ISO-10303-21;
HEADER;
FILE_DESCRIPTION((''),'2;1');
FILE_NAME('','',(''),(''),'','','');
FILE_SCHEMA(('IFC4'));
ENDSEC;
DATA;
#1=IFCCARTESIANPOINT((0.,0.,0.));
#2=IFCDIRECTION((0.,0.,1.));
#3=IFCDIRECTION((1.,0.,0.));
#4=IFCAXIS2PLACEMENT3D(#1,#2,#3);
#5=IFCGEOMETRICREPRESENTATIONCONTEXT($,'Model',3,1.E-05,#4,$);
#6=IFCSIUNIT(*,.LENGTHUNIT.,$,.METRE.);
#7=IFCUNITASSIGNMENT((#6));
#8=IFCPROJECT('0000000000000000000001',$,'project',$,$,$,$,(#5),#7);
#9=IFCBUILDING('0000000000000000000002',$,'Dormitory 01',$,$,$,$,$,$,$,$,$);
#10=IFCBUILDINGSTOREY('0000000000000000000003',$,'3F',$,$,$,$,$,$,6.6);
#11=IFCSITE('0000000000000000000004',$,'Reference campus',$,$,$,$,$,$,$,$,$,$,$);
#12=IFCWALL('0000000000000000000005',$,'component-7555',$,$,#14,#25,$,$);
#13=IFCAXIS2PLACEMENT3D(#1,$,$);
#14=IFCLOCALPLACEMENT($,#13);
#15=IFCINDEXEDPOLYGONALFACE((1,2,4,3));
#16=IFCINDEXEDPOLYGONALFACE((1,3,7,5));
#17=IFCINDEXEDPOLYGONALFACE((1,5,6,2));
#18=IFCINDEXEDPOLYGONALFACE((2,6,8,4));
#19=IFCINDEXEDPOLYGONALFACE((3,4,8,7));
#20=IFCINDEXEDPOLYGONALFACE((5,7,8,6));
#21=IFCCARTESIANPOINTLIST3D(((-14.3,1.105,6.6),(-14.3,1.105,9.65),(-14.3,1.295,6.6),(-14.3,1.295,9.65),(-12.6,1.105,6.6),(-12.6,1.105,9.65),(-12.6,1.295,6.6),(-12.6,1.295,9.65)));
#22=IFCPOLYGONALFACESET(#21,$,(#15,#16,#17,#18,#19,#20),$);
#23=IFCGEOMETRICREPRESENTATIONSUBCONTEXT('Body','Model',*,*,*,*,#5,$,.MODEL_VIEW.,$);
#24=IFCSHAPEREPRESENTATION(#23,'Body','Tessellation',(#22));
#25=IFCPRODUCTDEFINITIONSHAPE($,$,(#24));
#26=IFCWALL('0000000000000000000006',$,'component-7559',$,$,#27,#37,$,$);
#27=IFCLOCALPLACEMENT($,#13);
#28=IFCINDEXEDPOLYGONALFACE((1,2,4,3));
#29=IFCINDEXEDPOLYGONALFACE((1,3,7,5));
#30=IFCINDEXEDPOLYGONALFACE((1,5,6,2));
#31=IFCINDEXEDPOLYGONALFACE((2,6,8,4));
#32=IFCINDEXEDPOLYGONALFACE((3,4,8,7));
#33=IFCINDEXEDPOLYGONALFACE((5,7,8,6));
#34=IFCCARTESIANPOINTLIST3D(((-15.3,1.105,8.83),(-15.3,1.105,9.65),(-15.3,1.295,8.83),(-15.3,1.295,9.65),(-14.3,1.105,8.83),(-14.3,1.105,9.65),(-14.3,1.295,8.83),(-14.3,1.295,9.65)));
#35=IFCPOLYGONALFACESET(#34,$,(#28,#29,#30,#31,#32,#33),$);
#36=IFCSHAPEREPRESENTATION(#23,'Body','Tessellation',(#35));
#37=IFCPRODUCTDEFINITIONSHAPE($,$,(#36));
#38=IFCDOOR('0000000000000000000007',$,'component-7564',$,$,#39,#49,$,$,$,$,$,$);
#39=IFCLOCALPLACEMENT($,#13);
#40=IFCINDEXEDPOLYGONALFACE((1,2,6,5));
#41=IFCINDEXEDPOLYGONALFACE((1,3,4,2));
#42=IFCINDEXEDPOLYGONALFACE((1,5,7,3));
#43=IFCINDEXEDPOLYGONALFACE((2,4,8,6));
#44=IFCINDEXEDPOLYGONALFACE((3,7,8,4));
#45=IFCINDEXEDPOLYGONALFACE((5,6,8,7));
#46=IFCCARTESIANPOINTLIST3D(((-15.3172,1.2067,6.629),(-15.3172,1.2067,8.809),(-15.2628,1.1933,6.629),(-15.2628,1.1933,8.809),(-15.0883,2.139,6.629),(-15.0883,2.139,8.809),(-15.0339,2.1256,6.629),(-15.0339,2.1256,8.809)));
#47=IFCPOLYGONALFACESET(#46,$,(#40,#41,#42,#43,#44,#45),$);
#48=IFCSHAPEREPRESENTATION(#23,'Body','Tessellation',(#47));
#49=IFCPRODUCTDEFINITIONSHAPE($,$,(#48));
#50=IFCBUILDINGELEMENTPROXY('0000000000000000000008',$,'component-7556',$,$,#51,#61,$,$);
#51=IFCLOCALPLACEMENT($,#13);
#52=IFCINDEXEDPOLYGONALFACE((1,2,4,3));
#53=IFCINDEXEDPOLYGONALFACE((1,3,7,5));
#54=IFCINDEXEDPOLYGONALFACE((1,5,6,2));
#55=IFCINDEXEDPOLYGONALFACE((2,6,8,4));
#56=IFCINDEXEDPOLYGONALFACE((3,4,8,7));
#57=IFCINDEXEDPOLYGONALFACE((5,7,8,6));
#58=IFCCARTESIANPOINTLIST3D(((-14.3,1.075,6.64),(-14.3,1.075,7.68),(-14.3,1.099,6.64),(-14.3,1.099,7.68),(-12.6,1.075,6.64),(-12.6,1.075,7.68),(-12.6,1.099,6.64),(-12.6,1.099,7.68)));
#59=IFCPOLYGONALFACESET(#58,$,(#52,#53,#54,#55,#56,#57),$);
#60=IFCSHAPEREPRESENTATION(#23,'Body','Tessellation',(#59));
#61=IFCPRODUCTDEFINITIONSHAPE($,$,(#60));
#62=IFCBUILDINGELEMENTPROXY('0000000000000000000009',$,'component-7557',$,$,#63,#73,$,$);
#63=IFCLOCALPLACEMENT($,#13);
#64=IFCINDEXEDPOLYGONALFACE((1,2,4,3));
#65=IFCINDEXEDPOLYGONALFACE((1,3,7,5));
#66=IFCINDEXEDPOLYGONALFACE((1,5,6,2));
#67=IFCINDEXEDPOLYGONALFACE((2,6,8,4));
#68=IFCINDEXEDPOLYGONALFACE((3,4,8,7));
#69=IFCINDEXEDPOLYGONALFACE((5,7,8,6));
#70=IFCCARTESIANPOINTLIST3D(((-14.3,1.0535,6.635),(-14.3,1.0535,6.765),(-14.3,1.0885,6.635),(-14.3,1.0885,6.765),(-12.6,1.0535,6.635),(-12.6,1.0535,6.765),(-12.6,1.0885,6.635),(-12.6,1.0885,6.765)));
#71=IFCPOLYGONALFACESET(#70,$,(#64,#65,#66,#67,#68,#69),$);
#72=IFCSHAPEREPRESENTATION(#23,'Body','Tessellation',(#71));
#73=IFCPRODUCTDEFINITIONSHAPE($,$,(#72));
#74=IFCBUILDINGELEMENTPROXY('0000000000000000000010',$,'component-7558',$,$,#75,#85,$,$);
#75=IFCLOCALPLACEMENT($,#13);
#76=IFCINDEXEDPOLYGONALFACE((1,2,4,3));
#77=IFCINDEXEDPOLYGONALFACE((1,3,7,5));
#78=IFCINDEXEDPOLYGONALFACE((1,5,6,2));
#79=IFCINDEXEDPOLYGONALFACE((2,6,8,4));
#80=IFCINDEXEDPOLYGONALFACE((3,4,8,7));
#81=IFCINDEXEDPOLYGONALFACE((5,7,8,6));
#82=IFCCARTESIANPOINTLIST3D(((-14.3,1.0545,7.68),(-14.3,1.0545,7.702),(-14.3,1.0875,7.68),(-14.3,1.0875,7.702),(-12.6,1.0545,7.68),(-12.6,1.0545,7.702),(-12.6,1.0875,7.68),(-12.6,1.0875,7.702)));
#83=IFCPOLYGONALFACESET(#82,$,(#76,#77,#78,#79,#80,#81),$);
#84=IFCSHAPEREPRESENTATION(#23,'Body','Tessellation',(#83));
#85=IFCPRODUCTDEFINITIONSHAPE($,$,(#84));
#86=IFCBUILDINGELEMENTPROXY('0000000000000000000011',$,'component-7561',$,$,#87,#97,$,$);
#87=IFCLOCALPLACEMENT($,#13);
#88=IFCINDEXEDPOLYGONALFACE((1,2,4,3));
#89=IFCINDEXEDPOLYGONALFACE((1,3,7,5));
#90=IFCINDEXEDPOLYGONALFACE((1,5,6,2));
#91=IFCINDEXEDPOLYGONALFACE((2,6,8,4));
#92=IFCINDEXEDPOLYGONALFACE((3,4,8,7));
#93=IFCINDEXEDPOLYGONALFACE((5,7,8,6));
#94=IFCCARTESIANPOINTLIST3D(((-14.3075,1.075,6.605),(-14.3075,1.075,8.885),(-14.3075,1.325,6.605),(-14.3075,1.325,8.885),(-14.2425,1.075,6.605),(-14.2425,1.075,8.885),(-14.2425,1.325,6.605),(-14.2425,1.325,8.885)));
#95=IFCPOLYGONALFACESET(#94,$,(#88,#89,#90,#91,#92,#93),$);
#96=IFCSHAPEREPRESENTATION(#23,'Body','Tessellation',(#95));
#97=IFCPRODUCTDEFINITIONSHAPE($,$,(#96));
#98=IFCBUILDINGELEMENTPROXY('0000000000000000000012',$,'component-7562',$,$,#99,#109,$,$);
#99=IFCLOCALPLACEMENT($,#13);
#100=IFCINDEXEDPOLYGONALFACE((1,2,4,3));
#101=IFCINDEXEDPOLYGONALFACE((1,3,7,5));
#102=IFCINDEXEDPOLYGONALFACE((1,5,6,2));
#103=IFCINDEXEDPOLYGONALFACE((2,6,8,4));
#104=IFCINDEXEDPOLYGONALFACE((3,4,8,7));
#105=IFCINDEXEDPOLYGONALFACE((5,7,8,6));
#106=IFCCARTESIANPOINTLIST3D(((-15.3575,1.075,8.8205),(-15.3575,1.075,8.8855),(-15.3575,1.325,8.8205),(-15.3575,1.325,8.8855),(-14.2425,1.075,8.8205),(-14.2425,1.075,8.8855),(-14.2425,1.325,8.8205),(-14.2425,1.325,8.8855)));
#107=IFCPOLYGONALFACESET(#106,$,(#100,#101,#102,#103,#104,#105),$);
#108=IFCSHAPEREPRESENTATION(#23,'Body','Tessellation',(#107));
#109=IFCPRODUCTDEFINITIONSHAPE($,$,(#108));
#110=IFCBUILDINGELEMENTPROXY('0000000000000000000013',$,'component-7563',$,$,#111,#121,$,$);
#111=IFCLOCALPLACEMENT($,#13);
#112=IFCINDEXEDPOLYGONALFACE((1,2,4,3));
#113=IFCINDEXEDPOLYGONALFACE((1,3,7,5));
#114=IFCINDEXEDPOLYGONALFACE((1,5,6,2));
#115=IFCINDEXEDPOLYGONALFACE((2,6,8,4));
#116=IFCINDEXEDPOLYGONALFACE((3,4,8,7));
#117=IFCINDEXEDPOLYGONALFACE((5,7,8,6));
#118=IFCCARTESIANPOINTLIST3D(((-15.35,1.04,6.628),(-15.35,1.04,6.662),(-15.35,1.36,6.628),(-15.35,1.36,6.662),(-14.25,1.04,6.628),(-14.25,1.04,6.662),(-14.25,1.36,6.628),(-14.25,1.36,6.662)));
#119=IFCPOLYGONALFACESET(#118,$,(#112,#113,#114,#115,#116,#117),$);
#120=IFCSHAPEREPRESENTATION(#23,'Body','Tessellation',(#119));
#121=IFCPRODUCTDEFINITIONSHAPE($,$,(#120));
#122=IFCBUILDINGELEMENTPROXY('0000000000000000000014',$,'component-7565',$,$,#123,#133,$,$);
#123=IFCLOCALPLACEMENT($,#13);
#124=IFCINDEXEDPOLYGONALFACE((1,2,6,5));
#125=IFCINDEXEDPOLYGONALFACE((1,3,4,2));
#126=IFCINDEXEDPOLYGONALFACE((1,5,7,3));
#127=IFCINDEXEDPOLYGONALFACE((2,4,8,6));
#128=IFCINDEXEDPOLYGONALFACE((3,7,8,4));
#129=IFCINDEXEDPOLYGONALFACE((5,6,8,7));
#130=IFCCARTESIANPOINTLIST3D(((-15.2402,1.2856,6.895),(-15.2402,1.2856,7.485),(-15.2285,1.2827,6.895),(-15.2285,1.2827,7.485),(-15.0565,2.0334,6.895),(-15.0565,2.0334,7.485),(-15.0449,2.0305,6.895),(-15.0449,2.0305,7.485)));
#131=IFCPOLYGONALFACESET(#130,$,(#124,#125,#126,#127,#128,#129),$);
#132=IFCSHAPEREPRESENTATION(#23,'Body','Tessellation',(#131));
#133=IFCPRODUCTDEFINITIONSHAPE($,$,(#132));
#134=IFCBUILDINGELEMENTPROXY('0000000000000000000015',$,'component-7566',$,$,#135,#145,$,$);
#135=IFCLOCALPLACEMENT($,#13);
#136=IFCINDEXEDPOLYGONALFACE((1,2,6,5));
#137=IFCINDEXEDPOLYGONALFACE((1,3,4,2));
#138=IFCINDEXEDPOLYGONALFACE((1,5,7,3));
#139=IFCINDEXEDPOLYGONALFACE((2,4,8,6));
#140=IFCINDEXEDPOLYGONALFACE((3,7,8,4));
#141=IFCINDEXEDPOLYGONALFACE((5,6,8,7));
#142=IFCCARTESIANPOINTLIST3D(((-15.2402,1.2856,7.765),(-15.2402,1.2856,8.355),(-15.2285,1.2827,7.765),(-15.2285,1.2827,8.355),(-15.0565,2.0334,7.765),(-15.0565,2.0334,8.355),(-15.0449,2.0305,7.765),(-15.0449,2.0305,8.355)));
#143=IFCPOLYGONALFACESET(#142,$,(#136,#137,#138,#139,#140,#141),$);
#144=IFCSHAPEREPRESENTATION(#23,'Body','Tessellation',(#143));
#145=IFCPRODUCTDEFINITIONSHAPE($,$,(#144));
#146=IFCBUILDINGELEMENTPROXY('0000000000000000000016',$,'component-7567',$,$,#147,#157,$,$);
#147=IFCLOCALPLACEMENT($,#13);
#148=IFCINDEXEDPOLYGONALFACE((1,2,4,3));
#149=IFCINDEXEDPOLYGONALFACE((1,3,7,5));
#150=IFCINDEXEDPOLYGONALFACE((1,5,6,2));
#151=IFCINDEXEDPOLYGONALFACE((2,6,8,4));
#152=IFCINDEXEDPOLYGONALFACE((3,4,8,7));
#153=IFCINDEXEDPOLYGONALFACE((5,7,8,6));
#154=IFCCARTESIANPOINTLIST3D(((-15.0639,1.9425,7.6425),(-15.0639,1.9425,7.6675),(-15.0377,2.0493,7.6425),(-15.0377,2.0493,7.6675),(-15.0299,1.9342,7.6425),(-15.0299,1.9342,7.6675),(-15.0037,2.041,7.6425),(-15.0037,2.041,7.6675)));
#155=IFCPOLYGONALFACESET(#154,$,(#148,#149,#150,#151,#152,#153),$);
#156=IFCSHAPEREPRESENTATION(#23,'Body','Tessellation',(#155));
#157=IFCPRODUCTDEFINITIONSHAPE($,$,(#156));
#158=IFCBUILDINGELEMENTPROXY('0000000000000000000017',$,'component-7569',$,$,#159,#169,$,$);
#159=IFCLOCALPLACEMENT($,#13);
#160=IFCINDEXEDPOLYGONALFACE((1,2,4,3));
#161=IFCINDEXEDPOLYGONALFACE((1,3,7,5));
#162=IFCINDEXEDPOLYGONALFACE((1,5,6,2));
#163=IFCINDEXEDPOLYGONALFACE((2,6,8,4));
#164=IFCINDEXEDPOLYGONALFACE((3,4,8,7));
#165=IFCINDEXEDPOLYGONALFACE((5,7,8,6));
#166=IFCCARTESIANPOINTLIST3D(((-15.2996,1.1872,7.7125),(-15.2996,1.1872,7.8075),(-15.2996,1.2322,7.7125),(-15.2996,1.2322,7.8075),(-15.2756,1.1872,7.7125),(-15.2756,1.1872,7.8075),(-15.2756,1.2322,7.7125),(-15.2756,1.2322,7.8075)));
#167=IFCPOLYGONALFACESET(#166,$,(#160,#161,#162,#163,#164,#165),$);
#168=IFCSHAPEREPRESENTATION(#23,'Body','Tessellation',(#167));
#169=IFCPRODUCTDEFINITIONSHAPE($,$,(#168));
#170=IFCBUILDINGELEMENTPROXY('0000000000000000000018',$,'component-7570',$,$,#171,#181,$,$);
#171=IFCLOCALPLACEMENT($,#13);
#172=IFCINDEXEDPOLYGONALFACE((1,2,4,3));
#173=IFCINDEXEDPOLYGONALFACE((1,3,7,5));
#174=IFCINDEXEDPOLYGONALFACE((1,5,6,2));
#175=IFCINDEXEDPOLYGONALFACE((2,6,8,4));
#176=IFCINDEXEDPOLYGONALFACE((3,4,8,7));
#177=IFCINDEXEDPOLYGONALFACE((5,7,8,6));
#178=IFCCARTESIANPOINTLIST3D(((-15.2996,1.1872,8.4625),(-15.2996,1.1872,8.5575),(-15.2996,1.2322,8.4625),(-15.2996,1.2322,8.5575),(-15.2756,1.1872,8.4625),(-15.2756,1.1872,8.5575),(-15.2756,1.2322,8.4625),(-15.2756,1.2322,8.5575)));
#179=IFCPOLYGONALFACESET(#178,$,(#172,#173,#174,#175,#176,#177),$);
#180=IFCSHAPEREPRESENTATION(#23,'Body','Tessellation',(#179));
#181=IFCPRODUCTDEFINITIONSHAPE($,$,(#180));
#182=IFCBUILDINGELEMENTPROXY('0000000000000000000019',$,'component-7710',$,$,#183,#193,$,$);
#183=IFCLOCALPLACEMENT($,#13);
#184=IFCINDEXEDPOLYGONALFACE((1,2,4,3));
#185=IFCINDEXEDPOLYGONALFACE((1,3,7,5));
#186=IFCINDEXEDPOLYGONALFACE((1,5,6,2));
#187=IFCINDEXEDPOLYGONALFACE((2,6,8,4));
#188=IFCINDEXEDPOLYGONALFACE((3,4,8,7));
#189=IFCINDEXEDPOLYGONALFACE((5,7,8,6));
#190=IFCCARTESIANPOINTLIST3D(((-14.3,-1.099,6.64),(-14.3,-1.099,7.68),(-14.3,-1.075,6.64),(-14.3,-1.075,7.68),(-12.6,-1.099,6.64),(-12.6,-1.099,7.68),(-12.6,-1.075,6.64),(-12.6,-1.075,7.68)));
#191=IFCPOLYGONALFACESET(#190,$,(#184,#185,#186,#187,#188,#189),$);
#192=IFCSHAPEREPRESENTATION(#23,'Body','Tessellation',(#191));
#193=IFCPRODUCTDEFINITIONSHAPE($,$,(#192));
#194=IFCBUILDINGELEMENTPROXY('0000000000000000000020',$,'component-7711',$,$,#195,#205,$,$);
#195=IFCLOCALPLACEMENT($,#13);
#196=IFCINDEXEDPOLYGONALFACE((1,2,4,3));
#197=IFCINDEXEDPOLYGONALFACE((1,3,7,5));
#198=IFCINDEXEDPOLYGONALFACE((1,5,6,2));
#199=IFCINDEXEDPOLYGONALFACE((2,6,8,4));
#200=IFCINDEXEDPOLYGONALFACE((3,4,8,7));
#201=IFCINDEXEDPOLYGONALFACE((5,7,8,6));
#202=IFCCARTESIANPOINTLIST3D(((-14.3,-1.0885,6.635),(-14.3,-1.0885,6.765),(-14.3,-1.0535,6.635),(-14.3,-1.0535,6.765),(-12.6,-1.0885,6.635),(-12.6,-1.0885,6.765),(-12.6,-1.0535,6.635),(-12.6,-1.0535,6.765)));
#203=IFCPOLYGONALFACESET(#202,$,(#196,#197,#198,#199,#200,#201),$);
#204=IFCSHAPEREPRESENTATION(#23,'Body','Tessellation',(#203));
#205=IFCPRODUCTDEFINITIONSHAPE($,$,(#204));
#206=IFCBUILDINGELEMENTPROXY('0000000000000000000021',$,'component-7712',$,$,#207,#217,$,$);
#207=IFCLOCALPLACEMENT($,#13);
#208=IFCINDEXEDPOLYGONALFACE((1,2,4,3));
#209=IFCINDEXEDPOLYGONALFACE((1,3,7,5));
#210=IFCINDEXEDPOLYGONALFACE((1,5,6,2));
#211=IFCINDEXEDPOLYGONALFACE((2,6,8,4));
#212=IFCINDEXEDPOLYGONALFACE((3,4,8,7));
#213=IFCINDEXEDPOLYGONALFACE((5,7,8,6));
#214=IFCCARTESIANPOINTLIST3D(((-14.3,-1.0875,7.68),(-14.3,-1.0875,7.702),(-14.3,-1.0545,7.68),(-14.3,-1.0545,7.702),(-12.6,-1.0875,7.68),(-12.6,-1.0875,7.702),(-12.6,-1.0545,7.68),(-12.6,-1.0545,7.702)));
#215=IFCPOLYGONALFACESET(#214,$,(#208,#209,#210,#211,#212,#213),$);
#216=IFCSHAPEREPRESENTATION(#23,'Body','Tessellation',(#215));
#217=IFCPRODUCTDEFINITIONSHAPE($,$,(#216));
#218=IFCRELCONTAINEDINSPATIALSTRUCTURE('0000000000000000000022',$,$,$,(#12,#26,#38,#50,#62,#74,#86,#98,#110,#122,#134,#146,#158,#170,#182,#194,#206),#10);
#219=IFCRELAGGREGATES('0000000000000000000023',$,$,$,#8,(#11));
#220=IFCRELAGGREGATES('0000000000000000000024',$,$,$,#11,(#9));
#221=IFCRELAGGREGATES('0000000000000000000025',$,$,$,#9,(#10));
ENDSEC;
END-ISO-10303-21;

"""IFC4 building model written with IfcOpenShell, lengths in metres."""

from ifc_helpers import new_model, si_unit, frame, origin, origin_with_axes, origin_2d, place, context, subcontext, project, spatial, rectangle, extrude, element, save


model = new_model("IFC4")

# Units and contexts
model_context = context("Model", 3, precision=1e-05, world=origin_with_axes())
body_context = subcontext(model_context, "Body", "Model", "MODEL_VIEW")
ifc_project = project(units=[si_unit("LENGTHUNIT", "METRE")], contexts=[model_context])

# Site, building, storey
site = spatial("IfcSite", under=ifc_project, Name="Reference campus")
building = spatial("IfcBuilding", under=site, Name="Dormitory 01")
storey = spatial("IfcBuildingStorey", under=building, Name="3F", Elevation=6.6)

# Walls
wall_1_placement = place(None, frame((-13.45, 1.2, 6.6), z_axis=(0.0, 0.0, 1.0), x_axis=(1.0, 0.0, 0.0)))
element("IfcWall", 1, at=wall_1_placement, inside=storey, Name="component-7555", context=body_context, shape_type="SweptSolid", body=[
    extrude(rectangle(XDim=1.7, YDim=0.19, at=origin_2d()), origin(), (0.0, 0.0, 1.0), 3.05),
])
wall_2_placement = place(None, frame((-14.8, 1.2, 8.83), z_axis=(0.0, 0.0, 1.0), x_axis=(1.0, 0.0, 0.0)))
element("IfcWall", 2, at=wall_2_placement, inside=storey, Name="component-7559", context=body_context, shape_type="SweptSolid", body=[
    extrude(rectangle(XDim=1.0, YDim=0.19, at=origin_2d()), origin(), (0.0, 0.0, 1.0), 0.82),
])

# Door
door_placement = place(None, frame((-15.1755, 1.6662, 6.629), z_axis=(0.0, 0.0, 1.0), x_axis=(0.238476, 0.971148, 0.0)))
element("IfcDoor", 3, at=door_placement, inside=storey, Name="component-7564", context=body_context, shape_type="SweptSolid", body=[
    extrude(rectangle(XDim=0.96, YDim=0.056, at=origin_2d()), origin(), (0.0, 0.0, 1.0), 2.18),
])

# Building element proxies
proxy_1_placement = place(None, frame((-13.45, 1.087, 6.64), z_axis=(0.0, 0.0, 1.0), x_axis=(1.0, 0.0, 0.0)))
element("IfcBuildingElementProxy", 4, at=proxy_1_placement, inside=storey, Name="component-7556", context=body_context, shape_type="SweptSolid", body=[
    extrude(rectangle(XDim=1.7, YDim=0.024, at=origin_2d()), origin(), (0.0, 0.0, 1.0), 1.04),
])
proxy_2_placement = place(None, frame((-13.45, 1.071, 6.635), z_axis=(0.0, 0.0, 1.0), x_axis=(1.0, 0.0, 0.0)))
element("IfcBuildingElementProxy", 5, at=proxy_2_placement, inside=storey, Name="component-7557", context=body_context, shape_type="SweptSolid", body=[
    extrude(rectangle(XDim=1.7, YDim=0.035, at=origin_2d()), origin(), (0.0, 0.0, 1.0), 0.13),
])
proxy_3_placement = place(None, frame((-13.45, 1.071, 7.68), z_axis=(0.0, 0.0, 1.0), x_axis=(1.0, 0.0, 0.0)))
element("IfcBuildingElementProxy", 6, at=proxy_3_placement, inside=storey, Name="component-7558", context=body_context, shape_type="SweptSolid", body=[
    extrude(rectangle(XDim=1.7, YDim=0.033, at=origin_2d()), origin(), (0.0, 0.0, 1.0), 0.022),
])
proxy_4_placement = place(None, frame((-14.275, 1.2, 6.605), z_axis=(0.0, 0.0, 1.0), x_axis=(1.0, 0.0, 0.0)))
element("IfcBuildingElementProxy", 7, at=proxy_4_placement, inside=storey, Name="component-7561", context=body_context, shape_type="SweptSolid", body=[
    extrude(rectangle(XDim=0.065, YDim=0.25, at=origin_2d()), origin(), (0.0, 0.0, 1.0), 2.28),
])
proxy_5_placement = place(None, frame((-14.8, 1.2, 8.8205), z_axis=(0.0, 0.0, 1.0), x_axis=(1.0, 0.0, 0.0)))
element("IfcBuildingElementProxy", 8, at=proxy_5_placement, inside=storey, Name="component-7562", context=body_context, shape_type="SweptSolid", body=[
    extrude(rectangle(XDim=1.115, YDim=0.25, at=origin_2d()), origin(), (0.0, 0.0, 1.0), 0.065),
])
proxy_6_placement = place(None, frame((-14.8, 1.2, 6.628), z_axis=(0.0, 0.0, 1.0), x_axis=(1.0, 0.0, 0.0)))
element("IfcBuildingElementProxy", 9, at=proxy_6_placement, inside=storey, Name="component-7563", context=body_context, shape_type="SweptSolid", body=[
    extrude(rectangle(XDim=1.1, YDim=0.32, at=origin_2d()), origin(), (0.0, 0.0, 1.0), 0.034),
])
for number, where, z_axis, x_axis, name in (
    (10, (-15.1425, 1.658, 6.895), (0.0, 0.0, 1.0), (0.238476, 0.971148, 0.0), "component-7565"),
    (11, (-15.1425, 1.658, 7.765), (0.0, 0.0, 1.0), (0.238476, 0.971148, 0.0), "component-7566"),
):
    element("IfcBuildingElementProxy", number, at=place(None, frame(where, z_axis=z_axis, x_axis=x_axis)), inside=storey, Name=name, context=body_context, shape_type="SweptSolid", body=[
        extrude(rectangle(XDim=0.77, YDim=0.012, at=origin_2d()), origin(), (0.0, 0.0, 1.0), 0.59),
    ])
proxy_7_placement = place(None, frame((-15.0338, 1.9917, 7.6425), z_axis=(0.0, 0.0, 1.0), x_axis=(0.238476, 0.971148, 0.0)))
element("IfcBuildingElementProxy", 12, at=proxy_7_placement, inside=storey, Name="component-7567", context=body_context, shape_type="SweptSolid", body=[
    extrude(rectangle(XDim=0.11, YDim=0.035, at=origin_2d()), origin(), (0.0, 0.0, 1.0), 0.025),
])
for number, where, z_axis, x_axis, name in (
    (13, (-15.2876, 1.2097, 7.7125), (0.0, 0.0, 1.0), (1.0, 0.0, 0.0), "component-7569"),
    (14, (-15.2876, 1.2097, 8.4625), (0.0, 0.0, 1.0), (1.0, 0.0, 0.0), "component-7570"),
):
    element("IfcBuildingElementProxy", number, at=place(None, frame(where, z_axis=z_axis, x_axis=x_axis)), inside=storey, Name=name, context=body_context, shape_type="SweptSolid", body=[
        extrude(rectangle(XDim=0.024, YDim=0.045, at=origin_2d()), origin(), (0.0, 0.0, 1.0), 0.095),
    ])
proxy_8_placement = place(None, frame((-13.45, -1.087, 6.64), z_axis=(0.0, 0.0, 1.0), x_axis=(1.0, 0.0, 0.0)))
element("IfcBuildingElementProxy", 15, at=proxy_8_placement, inside=storey, Name="component-7710", context=body_context, shape_type="SweptSolid", body=[
    extrude(rectangle(XDim=1.7, YDim=0.024, at=origin_2d()), origin(), (0.0, 0.0, 1.0), 1.04),
])
proxy_9_placement = place(None, frame((-13.45, -1.071, 6.635), z_axis=(0.0, 0.0, 1.0), x_axis=(1.0, 0.0, 0.0)))
element("IfcBuildingElementProxy", 16, at=proxy_9_placement, inside=storey, Name="component-7711", context=body_context, shape_type="SweptSolid", body=[
    extrude(rectangle(XDim=1.7, YDim=0.035, at=origin_2d()), origin(), (0.0, 0.0, 1.0), 0.13),
])
proxy_10_placement = place(None, frame((-13.45, -1.071, 7.68), z_axis=(0.0, 0.0, 1.0), x_axis=(1.0, 0.0, 0.0)))
element("IfcBuildingElementProxy", 17, at=proxy_10_placement, inside=storey, Name="component-7712", context=body_context, shape_type="SweptSolid", body=[
    extrude(rectangle(XDim=1.7, YDim=0.033, at=origin_2d()), origin(), (0.0, 0.0, 1.0), 0.022),
])

save(model, "model.ifc")
